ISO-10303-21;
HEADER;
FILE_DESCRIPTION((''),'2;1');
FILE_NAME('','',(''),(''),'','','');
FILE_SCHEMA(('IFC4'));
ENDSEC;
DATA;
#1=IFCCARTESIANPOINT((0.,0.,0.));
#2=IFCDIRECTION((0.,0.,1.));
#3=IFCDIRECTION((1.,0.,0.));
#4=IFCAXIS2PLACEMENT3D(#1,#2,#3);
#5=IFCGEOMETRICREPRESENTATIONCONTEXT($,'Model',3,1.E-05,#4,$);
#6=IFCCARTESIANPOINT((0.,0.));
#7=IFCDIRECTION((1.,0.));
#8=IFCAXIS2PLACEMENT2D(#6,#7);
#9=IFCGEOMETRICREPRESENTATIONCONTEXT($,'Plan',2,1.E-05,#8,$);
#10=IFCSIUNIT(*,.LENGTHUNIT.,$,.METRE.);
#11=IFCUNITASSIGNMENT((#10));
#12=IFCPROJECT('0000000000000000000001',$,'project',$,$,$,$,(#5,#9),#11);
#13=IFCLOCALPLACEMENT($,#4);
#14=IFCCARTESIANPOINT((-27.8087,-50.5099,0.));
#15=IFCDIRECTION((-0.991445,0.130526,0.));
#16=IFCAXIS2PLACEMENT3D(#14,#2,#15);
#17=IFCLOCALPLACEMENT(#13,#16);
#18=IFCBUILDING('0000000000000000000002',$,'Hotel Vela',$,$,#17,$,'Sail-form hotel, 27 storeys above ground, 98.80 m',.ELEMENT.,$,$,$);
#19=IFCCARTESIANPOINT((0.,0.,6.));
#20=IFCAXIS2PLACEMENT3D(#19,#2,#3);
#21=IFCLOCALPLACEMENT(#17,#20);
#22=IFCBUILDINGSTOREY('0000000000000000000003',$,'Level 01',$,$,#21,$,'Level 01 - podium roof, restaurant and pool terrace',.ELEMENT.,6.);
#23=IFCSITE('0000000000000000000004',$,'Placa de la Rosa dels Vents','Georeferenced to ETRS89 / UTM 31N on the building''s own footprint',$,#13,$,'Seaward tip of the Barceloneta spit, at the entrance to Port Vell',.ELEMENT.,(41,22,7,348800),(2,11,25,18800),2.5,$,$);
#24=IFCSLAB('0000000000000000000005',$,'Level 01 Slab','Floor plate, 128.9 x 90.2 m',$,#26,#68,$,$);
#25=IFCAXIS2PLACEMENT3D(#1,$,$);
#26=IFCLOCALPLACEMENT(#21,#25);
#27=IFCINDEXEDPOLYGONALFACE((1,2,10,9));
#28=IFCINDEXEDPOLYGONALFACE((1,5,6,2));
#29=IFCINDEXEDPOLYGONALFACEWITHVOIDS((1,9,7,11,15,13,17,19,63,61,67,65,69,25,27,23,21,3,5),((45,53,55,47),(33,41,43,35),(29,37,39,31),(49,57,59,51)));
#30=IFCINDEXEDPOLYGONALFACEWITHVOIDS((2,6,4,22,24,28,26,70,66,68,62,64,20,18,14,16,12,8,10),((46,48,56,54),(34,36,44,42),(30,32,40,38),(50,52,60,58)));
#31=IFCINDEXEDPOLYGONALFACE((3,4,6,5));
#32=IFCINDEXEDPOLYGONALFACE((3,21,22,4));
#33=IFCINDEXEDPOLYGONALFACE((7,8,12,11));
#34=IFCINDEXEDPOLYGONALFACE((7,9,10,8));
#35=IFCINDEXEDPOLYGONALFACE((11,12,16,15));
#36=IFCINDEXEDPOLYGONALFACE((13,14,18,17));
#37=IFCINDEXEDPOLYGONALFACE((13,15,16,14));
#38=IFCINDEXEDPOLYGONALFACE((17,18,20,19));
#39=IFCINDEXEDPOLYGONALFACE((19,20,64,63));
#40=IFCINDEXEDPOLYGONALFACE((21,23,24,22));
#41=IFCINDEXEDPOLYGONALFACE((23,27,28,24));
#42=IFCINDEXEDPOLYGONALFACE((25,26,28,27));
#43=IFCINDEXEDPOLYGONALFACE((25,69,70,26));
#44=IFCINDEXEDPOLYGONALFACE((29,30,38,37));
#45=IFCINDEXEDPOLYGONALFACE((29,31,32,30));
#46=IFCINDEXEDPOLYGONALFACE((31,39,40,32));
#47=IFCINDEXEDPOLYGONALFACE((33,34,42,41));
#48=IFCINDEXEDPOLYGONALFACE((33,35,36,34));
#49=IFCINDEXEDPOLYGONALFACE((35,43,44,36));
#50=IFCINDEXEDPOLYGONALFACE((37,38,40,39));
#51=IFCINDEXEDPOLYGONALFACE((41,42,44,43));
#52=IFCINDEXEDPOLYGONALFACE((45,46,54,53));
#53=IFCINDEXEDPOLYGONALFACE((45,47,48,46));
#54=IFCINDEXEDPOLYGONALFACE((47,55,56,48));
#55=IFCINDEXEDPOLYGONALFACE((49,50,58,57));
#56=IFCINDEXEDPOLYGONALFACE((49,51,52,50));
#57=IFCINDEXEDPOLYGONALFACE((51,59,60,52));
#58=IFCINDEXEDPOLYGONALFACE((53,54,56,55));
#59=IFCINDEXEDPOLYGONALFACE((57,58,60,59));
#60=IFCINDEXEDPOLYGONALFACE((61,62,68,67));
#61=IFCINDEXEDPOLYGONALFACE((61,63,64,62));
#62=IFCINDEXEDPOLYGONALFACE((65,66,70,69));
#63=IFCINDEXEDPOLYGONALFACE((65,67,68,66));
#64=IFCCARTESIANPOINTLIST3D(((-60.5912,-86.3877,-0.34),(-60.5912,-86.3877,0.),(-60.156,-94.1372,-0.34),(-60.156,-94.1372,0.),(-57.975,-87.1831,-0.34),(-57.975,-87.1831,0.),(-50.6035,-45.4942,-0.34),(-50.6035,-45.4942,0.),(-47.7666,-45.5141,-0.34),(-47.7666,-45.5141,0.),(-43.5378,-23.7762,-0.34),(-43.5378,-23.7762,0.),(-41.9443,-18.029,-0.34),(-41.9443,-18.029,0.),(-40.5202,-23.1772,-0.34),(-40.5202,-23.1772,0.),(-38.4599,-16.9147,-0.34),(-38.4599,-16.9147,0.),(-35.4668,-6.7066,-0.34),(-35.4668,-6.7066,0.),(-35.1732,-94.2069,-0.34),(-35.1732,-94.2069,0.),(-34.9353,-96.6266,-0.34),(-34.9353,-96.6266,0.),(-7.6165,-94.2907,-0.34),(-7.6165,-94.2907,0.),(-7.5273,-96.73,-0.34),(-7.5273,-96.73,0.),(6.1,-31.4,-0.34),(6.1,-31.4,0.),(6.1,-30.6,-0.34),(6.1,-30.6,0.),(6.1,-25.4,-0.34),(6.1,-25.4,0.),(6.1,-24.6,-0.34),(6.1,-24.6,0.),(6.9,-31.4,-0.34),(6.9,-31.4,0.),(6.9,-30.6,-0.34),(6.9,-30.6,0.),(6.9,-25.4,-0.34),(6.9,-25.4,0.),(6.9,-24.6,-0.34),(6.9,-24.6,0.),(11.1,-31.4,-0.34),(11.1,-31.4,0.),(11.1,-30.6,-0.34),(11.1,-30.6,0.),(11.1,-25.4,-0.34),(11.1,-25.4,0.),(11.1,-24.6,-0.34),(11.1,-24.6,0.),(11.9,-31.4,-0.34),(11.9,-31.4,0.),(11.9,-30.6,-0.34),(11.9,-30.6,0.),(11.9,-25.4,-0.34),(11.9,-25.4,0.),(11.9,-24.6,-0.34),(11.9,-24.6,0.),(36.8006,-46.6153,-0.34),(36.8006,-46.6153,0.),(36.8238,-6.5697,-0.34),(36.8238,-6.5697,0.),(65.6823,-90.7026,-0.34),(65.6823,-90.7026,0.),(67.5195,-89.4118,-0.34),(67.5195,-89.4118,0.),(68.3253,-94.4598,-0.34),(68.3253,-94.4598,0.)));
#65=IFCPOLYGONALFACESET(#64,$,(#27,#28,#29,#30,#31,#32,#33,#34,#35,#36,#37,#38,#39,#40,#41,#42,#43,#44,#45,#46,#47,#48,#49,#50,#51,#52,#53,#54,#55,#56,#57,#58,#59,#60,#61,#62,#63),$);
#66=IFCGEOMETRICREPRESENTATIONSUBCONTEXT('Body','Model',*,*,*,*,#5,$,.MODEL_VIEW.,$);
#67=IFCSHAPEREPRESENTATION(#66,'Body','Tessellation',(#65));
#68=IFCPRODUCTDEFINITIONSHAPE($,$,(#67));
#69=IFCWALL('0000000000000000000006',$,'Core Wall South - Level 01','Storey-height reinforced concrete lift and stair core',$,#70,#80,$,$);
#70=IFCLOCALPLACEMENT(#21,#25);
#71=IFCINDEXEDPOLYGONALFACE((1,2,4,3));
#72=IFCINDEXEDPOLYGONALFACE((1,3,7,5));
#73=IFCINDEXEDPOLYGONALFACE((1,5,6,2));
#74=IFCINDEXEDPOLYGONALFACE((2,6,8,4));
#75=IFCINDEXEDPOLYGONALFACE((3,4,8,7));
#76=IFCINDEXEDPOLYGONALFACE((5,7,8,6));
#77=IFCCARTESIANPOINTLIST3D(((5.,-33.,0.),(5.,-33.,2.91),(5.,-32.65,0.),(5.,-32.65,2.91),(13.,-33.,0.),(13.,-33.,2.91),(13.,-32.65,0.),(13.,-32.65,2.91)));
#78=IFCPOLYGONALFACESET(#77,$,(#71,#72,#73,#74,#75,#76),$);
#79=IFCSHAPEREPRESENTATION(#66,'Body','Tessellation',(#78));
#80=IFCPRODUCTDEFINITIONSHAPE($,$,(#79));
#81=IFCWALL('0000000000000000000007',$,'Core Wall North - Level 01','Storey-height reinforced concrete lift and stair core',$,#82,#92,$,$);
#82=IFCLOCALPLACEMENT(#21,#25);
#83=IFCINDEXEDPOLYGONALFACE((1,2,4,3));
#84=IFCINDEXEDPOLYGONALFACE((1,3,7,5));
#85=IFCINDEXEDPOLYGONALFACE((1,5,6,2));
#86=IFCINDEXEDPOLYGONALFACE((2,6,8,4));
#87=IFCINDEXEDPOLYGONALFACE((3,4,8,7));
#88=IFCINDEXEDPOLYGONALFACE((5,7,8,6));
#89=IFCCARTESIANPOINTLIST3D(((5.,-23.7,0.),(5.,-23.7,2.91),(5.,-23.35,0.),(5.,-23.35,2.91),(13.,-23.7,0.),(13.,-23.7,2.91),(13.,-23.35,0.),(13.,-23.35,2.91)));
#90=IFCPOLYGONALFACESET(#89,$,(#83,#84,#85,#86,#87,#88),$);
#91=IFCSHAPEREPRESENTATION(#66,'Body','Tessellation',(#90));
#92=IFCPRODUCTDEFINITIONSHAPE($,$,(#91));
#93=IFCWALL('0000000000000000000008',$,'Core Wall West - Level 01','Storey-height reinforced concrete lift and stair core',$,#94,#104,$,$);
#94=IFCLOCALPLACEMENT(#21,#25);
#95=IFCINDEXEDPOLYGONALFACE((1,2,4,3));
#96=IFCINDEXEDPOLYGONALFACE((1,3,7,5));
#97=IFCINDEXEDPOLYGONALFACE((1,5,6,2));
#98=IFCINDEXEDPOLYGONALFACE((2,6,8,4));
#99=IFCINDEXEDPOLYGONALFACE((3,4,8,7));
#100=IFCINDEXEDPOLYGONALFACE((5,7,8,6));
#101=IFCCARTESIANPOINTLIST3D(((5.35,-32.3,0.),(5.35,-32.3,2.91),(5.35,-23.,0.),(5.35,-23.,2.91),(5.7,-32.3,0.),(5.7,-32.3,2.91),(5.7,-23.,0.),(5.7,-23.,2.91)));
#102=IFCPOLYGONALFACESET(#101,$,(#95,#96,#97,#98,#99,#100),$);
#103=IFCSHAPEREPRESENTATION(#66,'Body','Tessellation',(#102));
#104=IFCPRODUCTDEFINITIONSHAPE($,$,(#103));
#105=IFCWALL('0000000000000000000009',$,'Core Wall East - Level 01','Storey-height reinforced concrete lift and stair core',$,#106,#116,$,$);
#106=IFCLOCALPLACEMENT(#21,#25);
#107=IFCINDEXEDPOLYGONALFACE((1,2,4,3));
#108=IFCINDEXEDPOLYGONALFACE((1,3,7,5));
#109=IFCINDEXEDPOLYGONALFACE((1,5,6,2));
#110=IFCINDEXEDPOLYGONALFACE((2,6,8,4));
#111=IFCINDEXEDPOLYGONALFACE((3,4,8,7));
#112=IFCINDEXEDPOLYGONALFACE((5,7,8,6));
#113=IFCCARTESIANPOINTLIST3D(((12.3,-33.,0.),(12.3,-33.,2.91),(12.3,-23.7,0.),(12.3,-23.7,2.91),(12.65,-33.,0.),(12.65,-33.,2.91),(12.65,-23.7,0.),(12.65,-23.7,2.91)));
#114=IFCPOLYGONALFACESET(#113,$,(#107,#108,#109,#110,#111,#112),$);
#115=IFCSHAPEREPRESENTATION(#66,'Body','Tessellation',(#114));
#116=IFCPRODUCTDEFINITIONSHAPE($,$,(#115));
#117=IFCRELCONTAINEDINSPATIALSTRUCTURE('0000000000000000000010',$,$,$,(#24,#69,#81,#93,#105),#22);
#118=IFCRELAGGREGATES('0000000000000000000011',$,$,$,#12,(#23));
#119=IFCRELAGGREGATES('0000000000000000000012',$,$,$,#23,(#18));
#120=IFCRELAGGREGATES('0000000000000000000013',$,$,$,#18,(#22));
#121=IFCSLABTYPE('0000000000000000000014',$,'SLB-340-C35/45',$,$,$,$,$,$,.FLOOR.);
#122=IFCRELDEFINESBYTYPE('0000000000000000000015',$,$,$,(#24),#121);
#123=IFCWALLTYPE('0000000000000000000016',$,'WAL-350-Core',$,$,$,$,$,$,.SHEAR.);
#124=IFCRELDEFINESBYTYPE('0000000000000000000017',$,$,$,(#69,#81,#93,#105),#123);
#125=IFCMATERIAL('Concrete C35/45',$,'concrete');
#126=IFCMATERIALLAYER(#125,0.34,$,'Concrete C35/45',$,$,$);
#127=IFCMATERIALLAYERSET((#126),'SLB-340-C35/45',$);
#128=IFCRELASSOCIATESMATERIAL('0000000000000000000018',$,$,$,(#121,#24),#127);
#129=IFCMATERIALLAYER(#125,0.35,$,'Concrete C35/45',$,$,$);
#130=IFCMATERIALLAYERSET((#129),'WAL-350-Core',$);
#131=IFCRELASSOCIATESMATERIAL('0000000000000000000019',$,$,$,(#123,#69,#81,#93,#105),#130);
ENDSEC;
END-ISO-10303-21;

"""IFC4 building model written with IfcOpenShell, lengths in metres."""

from ifc_helpers import new_model, si_unit, frame, origin_with_axes, origin_2d_with_axis, place, context, subcontext, project, spatial, line, indexed_curve, outline, extrude, material, layer, layer_set, layer_usage, type_object, element, save


model = new_model("IFC4")

# Units and contexts
model_context = context("Model", 3, precision=1e-05, world=origin_with_axes())
plan_context = context("Plan", 2, precision=1e-05, world=origin_2d_with_axis())
body_context = subcontext(model_context, "Body", "Model", "MODEL_VIEW")
ifc_project = project(units=[si_unit("LENGTHUNIT", "METRE")], contexts=[model_context, plan_context])

# Site, building, storey
site_placement = place(None, origin_with_axes())
site = spatial("IfcSite", under=ifc_project, at=site_placement, Name="Placa de la Rosa dels Vents", Description="Georeferenced to ETRS89 / UTM 31N on the building's own footprint", LongName="Seaward tip of the Barceloneta spit, at the entrance to Port Vell", CompositionType="ELEMENT", RefLatitude=(41, 22, 7, 348800), RefLongitude=(2, 11, 25, 18800), RefElevation=2.5)
building_placement = place(site_placement, frame((-27.8087, -50.5099, 0.0), z_axis=(0.0, 0.0, 1.0), x_axis=(-0.991445, 0.130526, 0.0)))
building = spatial("IfcBuilding", under=site, at=building_placement, Name="Hotel Vela", LongName="Sail-form hotel, 27 storeys above ground, 98.80 m", CompositionType="ELEMENT")
storey_placement = place(building_placement, frame((0.0, 0.0, 6.0), z_axis=(0.0, 0.0, 1.0), x_axis=(1.0, 0.0, 0.0)))
storey = spatial("IfcBuildingStorey", under=building, at=storey_placement, Name="Level 01", LongName="Level 01 - podium roof, restaurant and pool terrace", CompositionType="ELEMENT", Elevation=6.0)

# Shared definitions
ifc_material = material(Name="Concrete C35/45", Category="concrete")

# Slab, openings
ifc_layer_1 = layer(ifc_material, 0.34, Name="Concrete C35/45")
ifc_layer_set_1 = layer_set([ifc_layer_1], Name="SLB-340-C35/45")
ifc_layer_usage_1 = layer_usage(ifc_layer_set_1, "AXIS3", "POSITIVE", 0.0)
slab_type = type_object("IfcSlabType", Name="SLB-340-C35/45", PredefinedType="FLOOR", material=ifc_layer_set_1)
slab_placement = place(storey_placement, frame((0.0, 0.0, -0.34), z_axis=(0.0, 0.0, 1.0), x_axis=(1.0, 0.0, 0.0)))
slab = element("IfcSlab", 1, at=slab_placement, inside=storey, type_object=slab_type, material=ifc_layer_usage_1, Name="Level 01 Slab", Description="Floor plate, 128.9 x 90.2 m", context=body_context, shape_type="SweptSolid", body=[
    extrude(outline(indexed_curve([(-60.156, -94.1372), (-35.1732, -94.2069), (-34.9353, -96.6266), (-7.5273, -96.73), (-7.6165, -94.2907), (68.3253, -94.4598), (65.6823, -90.7026), (67.5195, -89.4118), (36.8006, -46.6153), (36.8238, -6.5697), (-35.4668, -6.7066), (-38.4599, -16.9147), (-41.9443, -18.029), (-40.5202, -23.1772), (-43.5378, -23.7762), (-50.6035, -45.4942), (-47.7666, -45.5141), (-60.5912, -86.3877), (-57.975, -87.1831)], segments=[line(1, 2, 3, 4, 5, 6, 7, 8, 9, 10, 11, 12, 13, 14, 15, 16, 17, 18, 19, 1)])), origin_with_axes(), (0.0, 0.0, 1.0), 0.34),
])
opening_1_placement = place(slab_placement, frame((6.1, -31.4, -0.05), z_axis=(0.0, 0.0, 1.0), x_axis=(1.0, 0.0, 0.0)))
element("IfcOpeningElement", 2, at=opening_1_placement, cuts=slab, PredefinedType="OPENING", context=body_context, shape_type="SweptSolid", body=[
    extrude(outline(indexed_curve([(0.0, 0.0), (0.8, 0.0), (0.8, 0.8), (0.0, 0.8)], segments=[line(1, 2, 3, 4, 1)])), origin_with_axes(), (0.0, 0.0, 1.0), 0.44),
])
opening_2_placement = place(slab_placement, frame((6.1, -25.4, -0.05), z_axis=(0.0, 0.0, 1.0), x_axis=(1.0, 0.0, 0.0)))
element("IfcOpeningElement", 3, at=opening_2_placement, cuts=slab, PredefinedType="OPENING", context=body_context, shape_type="SweptSolid", body=[
    extrude(outline(indexed_curve([(0.0, 0.0), (0.8, 0.0), (0.8, 0.8), (0.0, 0.8)], segments=[line(1, 2, 3, 4, 1)])), origin_with_axes(), (0.0, 0.0, 1.0), 0.44),
])
opening_3_placement = place(slab_placement, frame((11.1, -31.4, -0.05), z_axis=(0.0, 0.0, 1.0), x_axis=(1.0, 0.0, 0.0)))
element("IfcOpeningElement", 4, at=opening_3_placement, cuts=slab, PredefinedType="OPENING", context=body_context, shape_type="SweptSolid", body=[
    extrude(outline(indexed_curve([(0.0, 0.0), (0.8, 0.0), (0.8, 0.8), (0.0, 0.8)], segments=[line(1, 2, 3, 4, 1)])), origin_with_axes(), (0.0, 0.0, 1.0), 0.44),
])
opening_4_placement = place(slab_placement, frame((11.1, -25.4, -0.05), z_axis=(0.0, 0.0, 1.0), x_axis=(1.0, 0.0, 0.0)))
element("IfcOpeningElement", 5, at=opening_4_placement, cuts=slab, PredefinedType="OPENING", context=body_context, shape_type="SweptSolid", body=[
    extrude(outline(indexed_curve([(0.0, 0.0), (0.8, 0.0), (0.8, 0.8), (0.0, 0.8)], segments=[line(1, 2, 3, 4, 1)])), origin_with_axes(), (0.0, 0.0, 1.0), 0.44),
])

# Walls
ifc_layer_2 = layer(ifc_material, 0.35, Name="Concrete C35/45")
ifc_layer_set_2 = layer_set([ifc_layer_2], Name="WAL-350-Core")
ifc_layer_usage_2 = layer_usage(ifc_layer_set_2, "AXIS2", "POSITIVE", 0.0)
wall_type = type_object("IfcWallType", Name="WAL-350-Core", PredefinedType="SHEAR", material=ifc_layer_set_2)
wall_1_placement = place(storey_placement, frame((5.0, -33.0, 0.0), z_axis=(0.0, 0.0, 1.0), x_axis=(1.0, 0.0, 0.0)))
element("IfcWall", 6, at=wall_1_placement, inside=storey, type_object=wall_type, material=ifc_layer_usage_2, Name="Core Wall South - Level 01", Description="Storey-height reinforced concrete lift and stair core", context=body_context, shape_type="SweptSolid", body=[
    extrude(outline(indexed_curve([(0.0, 0.0), (8.0, 0.0), (8.0, 0.35), (0.0, 0.35)], segments=[line(1, 2, 3, 4, 1)])), origin_with_axes(), (0.0, 0.0, 1.0), 2.91),
])
ifc_layer_usage_3 = layer_usage(ifc_layer_set_2, "AXIS2", "POSITIVE", 0.0)
wall_2_placement = place(storey_placement, frame((13.0, -23.35, 0.0), z_axis=(0.0, 0.0, 1.0), x_axis=(-1.0, 0.0, 0.0)))
element("IfcWall", 7, at=wall_2_placement, inside=storey, type_object=wall_type, material=ifc_layer_usage_3, Name="Core Wall North - Level 01", Description="Storey-height reinforced concrete lift and stair core", context=body_context, shape_type="SweptSolid", body=[
    extrude(outline(indexed_curve([(0.0, 0.0), (8.0, 0.0), (8.0, 0.35), (0.0, 0.35)], segments=[line(1, 2, 3, 4, 1)])), origin_with_axes(), (0.0, 0.0, 1.0), 2.91),
])
ifc_layer_usage_4 = layer_usage(ifc_layer_set_2, "AXIS2", "POSITIVE", 0.0)
wall_3_placement = place(storey_placement, frame((5.35, -23.0, 0.0), z_axis=(0.0, 0.0, 1.0), x_axis=(0.0, -1.0, 0.0)))
element("IfcWall", 8, at=wall_3_placement, inside=storey, type_object=wall_type, material=ifc_layer_usage_4, Name="Core Wall West - Level 01", Description="Storey-height reinforced concrete lift and stair core", context=body_context, shape_type="SweptSolid", body=[
    extrude(outline(indexed_curve([(0.0, 0.0), (9.3, 0.0), (9.3, 0.35), (0.0, 0.35)], segments=[line(1, 2, 3, 4, 1)])), origin_with_axes(), (0.0, 0.0, 1.0), 2.91),
])
ifc_layer_usage_5 = layer_usage(ifc_layer_set_2, "AXIS2", "POSITIVE", 0.0)
wall_4_placement = place(storey_placement, frame((12.65, -33.0, 0.0), z_axis=(0.0, 0.0, 1.0), x_axis=(0.0, 1.0, 0.0)))
element("IfcWall", 9, at=wall_4_placement, inside=storey, type_object=wall_type, material=ifc_layer_usage_5, Name="Core Wall East - Level 01", Description="Storey-height reinforced concrete lift and stair core", context=body_context, shape_type="SweptSolid", body=[
    extrude(outline(indexed_curve([(0.0, 0.0), (9.3, 0.0), (9.3, 0.35), (0.0, 0.35)], segments=[line(1, 2, 3, 4, 1)])), origin_with_axes(), (0.0, 0.0, 1.0), 2.91),
])

save(model, "model.ifc")
